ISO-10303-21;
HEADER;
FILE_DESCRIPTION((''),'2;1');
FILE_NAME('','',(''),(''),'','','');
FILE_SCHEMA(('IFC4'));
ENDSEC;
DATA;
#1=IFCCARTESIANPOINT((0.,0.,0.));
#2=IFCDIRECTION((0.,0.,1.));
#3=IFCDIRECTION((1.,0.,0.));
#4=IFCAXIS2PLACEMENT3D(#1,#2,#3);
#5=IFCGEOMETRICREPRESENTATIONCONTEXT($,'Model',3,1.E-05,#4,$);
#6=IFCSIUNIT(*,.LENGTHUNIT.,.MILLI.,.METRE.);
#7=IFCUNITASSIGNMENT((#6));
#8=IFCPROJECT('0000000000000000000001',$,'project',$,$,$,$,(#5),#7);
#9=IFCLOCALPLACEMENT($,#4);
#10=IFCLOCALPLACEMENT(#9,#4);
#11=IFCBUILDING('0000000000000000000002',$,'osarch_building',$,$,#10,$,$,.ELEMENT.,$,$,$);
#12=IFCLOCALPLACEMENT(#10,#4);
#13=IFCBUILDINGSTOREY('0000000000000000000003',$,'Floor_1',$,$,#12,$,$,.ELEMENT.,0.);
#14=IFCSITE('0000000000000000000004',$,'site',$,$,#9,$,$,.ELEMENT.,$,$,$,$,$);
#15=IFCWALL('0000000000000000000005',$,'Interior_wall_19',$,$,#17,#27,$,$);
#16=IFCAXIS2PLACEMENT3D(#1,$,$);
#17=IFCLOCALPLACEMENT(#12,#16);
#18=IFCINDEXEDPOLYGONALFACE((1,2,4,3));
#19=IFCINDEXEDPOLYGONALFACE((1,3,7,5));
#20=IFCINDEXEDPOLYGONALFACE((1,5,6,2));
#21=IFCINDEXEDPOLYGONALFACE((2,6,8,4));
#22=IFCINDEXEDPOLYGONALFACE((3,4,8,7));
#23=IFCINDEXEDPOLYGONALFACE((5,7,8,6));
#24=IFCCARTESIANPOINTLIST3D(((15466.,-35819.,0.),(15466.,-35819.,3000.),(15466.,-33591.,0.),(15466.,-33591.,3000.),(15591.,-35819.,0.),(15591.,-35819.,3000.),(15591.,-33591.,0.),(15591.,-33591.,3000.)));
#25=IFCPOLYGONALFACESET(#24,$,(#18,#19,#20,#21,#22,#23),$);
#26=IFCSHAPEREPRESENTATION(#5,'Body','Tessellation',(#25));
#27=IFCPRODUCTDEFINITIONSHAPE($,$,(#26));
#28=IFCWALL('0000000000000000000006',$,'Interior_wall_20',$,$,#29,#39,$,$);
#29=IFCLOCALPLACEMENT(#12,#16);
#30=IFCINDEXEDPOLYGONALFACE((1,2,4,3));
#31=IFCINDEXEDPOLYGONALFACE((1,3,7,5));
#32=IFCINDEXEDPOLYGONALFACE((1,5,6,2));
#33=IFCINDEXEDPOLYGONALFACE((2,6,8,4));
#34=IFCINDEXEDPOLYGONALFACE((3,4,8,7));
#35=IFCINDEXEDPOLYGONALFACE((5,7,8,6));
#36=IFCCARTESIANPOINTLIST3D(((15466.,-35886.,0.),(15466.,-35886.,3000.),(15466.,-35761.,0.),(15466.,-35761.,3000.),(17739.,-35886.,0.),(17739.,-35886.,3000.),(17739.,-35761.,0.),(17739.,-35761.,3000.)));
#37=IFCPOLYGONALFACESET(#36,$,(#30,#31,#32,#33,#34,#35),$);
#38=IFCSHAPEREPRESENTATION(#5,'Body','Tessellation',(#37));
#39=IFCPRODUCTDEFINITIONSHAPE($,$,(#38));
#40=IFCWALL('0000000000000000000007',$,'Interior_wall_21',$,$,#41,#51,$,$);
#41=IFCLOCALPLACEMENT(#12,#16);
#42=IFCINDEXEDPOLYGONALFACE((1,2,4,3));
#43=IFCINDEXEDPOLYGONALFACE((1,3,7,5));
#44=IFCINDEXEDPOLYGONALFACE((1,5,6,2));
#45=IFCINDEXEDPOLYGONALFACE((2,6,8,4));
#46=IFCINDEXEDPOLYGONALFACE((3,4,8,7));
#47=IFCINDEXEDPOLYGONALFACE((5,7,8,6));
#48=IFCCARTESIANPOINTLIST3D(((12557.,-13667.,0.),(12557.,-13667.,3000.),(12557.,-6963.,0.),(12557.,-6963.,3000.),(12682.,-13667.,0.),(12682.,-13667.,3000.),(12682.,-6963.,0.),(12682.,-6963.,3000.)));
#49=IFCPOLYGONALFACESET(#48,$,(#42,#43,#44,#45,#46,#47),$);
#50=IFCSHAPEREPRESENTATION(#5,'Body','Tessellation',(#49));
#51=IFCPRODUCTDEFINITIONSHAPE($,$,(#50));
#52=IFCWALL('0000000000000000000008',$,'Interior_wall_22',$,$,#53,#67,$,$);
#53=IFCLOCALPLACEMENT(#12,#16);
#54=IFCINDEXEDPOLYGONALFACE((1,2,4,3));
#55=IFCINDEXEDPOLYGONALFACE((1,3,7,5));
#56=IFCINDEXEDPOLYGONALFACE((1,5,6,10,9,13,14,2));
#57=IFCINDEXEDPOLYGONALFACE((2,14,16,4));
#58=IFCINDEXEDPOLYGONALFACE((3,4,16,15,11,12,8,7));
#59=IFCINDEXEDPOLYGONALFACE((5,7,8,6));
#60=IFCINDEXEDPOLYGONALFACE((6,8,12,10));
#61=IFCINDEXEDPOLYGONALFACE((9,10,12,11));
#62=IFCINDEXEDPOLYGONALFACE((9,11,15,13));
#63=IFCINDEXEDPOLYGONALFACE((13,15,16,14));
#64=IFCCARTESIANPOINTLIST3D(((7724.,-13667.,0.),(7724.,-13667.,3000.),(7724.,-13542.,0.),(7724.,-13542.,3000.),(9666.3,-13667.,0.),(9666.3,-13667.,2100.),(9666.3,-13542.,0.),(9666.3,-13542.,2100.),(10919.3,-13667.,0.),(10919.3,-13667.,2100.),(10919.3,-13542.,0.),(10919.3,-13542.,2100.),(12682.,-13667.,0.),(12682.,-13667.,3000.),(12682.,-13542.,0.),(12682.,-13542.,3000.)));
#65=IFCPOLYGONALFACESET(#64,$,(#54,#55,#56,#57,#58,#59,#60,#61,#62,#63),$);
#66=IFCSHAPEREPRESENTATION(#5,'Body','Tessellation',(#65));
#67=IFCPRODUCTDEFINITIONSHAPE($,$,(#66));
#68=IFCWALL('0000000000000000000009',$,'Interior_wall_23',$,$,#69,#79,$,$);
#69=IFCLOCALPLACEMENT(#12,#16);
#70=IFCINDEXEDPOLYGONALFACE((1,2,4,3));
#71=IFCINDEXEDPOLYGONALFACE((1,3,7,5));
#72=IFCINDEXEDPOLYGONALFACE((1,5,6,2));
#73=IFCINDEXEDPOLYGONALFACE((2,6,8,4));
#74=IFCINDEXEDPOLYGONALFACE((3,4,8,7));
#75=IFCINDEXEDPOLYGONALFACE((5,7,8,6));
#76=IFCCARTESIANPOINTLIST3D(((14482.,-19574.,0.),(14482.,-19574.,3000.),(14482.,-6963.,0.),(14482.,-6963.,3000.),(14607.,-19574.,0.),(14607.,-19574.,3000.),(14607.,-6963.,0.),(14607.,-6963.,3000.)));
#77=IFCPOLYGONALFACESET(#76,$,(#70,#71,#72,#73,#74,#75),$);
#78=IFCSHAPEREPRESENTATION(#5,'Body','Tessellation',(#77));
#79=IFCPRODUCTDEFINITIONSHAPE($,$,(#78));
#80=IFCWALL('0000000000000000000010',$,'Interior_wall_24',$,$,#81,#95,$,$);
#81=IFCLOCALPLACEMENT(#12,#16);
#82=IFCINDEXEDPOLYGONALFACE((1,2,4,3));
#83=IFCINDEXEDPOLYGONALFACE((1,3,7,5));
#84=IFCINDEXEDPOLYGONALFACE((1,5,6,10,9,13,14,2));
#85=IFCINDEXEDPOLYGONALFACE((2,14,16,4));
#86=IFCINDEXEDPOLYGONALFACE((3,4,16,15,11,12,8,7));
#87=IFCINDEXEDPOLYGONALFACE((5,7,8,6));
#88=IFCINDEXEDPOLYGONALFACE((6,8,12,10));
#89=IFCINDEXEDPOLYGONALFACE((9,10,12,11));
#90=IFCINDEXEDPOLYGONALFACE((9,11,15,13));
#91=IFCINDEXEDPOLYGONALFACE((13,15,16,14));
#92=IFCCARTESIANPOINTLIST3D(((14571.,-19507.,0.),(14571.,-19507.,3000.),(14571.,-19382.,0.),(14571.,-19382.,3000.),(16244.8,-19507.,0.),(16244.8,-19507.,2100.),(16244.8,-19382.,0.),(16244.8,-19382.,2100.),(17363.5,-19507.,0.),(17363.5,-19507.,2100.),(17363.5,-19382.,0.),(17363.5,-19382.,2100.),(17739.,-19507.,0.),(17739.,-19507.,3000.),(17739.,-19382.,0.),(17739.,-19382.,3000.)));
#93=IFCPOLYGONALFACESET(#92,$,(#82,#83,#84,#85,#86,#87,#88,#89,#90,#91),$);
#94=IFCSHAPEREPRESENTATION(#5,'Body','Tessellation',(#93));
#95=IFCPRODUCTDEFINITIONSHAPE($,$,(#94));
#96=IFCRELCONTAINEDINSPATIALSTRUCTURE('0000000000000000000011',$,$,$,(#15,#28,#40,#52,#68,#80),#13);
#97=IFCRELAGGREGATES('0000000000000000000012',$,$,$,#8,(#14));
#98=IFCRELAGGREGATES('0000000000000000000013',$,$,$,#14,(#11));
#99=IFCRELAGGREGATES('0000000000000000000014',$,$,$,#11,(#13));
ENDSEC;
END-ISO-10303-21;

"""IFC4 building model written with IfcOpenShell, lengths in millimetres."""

from ifc_helpers import new_model, si_unit, origin_with_axes, place, context, project, spatial, polyline, outline, extrude, element, save


model = new_model("IFC4")

# Units and contexts
model_context = context("Model", 3, precision=1e-05, world=origin_with_axes())
ifc_project = project(units=[si_unit("LENGTHUNIT", "METRE", prefix="MILLI")], contexts=[model_context])

# Site, building, storey
site_placement = place(None, origin_with_axes())
site = spatial("IfcSite", under=ifc_project, at=site_placement, Name="site", CompositionType="ELEMENT")
building_placement = place(site_placement, origin_with_axes())
building = spatial("IfcBuilding", under=site, at=building_placement, Name="osarch_building", CompositionType="ELEMENT")
storey_placement = place(building_placement, origin_with_axes())
storey = spatial("IfcBuildingStorey", under=building, at=storey_placement, Name="Floor_1", CompositionType="ELEMENT", Elevation=0.0)

# Walls
element("IfcWall", 1, inside=storey, Name="Interior_wall_19", context=model_context, shape_type="SweptSolid", body=[
    extrude(outline(polyline([(15466.0, -33591.0, 0.0), (15591.0, -33591.0, 0.0), (15591.0, -35819.0, 0.0), (15466.0, -35819.0, 0.0), (15466.0, -33591.0, 0.0)])), origin_with_axes(), (0.0, 0.0, 1.0), 3000.0),
])
element("IfcWall", 2, inside=storey, Name="Interior_wall_20", context=model_context, shape_type="SweptSolid", body=[
    extrude(outline(polyline([(17739.0, -35761.0, 0.0), (17739.0, -35886.0, 0.0), (15466.0, -35886.0, 0.0), (15466.0, -35761.0, 0.0), (17739.0, -35761.0, 0.0)])), origin_with_axes(), (0.0, 0.0, 1.0), 3000.0),
])
element("IfcWall", 3, inside=storey, Name="Interior_wall_21", context=model_context, shape_type="SweptSolid", body=[
    extrude(outline(polyline([(12557.0, -6963.0, 0.0), (12682.0, -6963.0, 0.0), (12682.0, -13667.0, 0.0), (12557.0, -13667.0, 0.0), (12557.0, -6963.0, 0.0)])), origin_with_axes(), (0.0, 0.0, 1.0), 3000.0),
])

# Wall, opening
wall_1 = element("IfcWall", 4, inside=storey, Name="Interior_wall_22", context=model_context, shape_type="SweptSolid", body=[
    extrude(outline(polyline([(12682.0, -13542.0, 0.0), (12682.0, -13667.0, 0.0), (7724.0, -13667.0, 0.0), (7724.0, -13542.0, 0.0), (12682.0, -13542.0, 0.0)])), origin_with_axes(), (0.0, 0.0, 1.0), 3000.0),
])
element("IfcOpeningElement", 5, inside=storey, cuts=wall_1, context=model_context, shape_type="SweptSolid", body=[
    extrude(outline(polyline([(9666.3, -13335.9, 0.0), (9666.3, -14902.2, 0.0), (10919.3, -14902.2, 0.0), (10919.3, -13335.9, 0.0), (9666.3, -13335.9, 0.0)])), origin_with_axes(), (0.0, 0.0, 1.0), 2100.0),
])

# Wall
element("IfcWall", 6, inside=storey, Name="Interior_wall_23", context=model_context, shape_type="SweptSolid", body=[
    extrude(outline(polyline([(14482.0, -6963.0, 0.0), (14607.0, -6963.0, 0.0), (14607.0, -19574.0, 0.0), (14482.0, -19574.0, 0.0), (14482.0, -6963.0, 0.0)])), origin_with_axes(), (0.0, 0.0, 1.0), 3000.0),
])

# Wall, opening
wall_2 = element("IfcWall", 7, inside=storey, Name="Interior_wall_24", context=model_context, shape_type="SweptSolid", body=[
    extrude(outline(polyline([(17739.0, -19382.0, 0.0), (17739.0, -19507.0, 0.0), (14571.0, -19507.0, 0.0), (14571.0, -19382.0, 0.0), (17739.0, -19382.0, 0.0)])), origin_with_axes(), (0.0, 0.0, 1.0), 3000.0),
])
element("IfcOpeningElement", 8, inside=storey, cuts=wall_2, context=model_context, shape_type="SweptSolid", body=[
    extrude(outline(polyline([(16244.8, -19153.6, 0.0), (16244.8, -20093.4, 0.0), (17363.5, -20093.4, 0.0), (17363.5, -19153.6, 0.0), (16244.8, -19153.6, 0.0)])), origin_with_axes(), (0.0, 0.0, 1.0), 2100.0),
])

save(model, "model.ifc")
